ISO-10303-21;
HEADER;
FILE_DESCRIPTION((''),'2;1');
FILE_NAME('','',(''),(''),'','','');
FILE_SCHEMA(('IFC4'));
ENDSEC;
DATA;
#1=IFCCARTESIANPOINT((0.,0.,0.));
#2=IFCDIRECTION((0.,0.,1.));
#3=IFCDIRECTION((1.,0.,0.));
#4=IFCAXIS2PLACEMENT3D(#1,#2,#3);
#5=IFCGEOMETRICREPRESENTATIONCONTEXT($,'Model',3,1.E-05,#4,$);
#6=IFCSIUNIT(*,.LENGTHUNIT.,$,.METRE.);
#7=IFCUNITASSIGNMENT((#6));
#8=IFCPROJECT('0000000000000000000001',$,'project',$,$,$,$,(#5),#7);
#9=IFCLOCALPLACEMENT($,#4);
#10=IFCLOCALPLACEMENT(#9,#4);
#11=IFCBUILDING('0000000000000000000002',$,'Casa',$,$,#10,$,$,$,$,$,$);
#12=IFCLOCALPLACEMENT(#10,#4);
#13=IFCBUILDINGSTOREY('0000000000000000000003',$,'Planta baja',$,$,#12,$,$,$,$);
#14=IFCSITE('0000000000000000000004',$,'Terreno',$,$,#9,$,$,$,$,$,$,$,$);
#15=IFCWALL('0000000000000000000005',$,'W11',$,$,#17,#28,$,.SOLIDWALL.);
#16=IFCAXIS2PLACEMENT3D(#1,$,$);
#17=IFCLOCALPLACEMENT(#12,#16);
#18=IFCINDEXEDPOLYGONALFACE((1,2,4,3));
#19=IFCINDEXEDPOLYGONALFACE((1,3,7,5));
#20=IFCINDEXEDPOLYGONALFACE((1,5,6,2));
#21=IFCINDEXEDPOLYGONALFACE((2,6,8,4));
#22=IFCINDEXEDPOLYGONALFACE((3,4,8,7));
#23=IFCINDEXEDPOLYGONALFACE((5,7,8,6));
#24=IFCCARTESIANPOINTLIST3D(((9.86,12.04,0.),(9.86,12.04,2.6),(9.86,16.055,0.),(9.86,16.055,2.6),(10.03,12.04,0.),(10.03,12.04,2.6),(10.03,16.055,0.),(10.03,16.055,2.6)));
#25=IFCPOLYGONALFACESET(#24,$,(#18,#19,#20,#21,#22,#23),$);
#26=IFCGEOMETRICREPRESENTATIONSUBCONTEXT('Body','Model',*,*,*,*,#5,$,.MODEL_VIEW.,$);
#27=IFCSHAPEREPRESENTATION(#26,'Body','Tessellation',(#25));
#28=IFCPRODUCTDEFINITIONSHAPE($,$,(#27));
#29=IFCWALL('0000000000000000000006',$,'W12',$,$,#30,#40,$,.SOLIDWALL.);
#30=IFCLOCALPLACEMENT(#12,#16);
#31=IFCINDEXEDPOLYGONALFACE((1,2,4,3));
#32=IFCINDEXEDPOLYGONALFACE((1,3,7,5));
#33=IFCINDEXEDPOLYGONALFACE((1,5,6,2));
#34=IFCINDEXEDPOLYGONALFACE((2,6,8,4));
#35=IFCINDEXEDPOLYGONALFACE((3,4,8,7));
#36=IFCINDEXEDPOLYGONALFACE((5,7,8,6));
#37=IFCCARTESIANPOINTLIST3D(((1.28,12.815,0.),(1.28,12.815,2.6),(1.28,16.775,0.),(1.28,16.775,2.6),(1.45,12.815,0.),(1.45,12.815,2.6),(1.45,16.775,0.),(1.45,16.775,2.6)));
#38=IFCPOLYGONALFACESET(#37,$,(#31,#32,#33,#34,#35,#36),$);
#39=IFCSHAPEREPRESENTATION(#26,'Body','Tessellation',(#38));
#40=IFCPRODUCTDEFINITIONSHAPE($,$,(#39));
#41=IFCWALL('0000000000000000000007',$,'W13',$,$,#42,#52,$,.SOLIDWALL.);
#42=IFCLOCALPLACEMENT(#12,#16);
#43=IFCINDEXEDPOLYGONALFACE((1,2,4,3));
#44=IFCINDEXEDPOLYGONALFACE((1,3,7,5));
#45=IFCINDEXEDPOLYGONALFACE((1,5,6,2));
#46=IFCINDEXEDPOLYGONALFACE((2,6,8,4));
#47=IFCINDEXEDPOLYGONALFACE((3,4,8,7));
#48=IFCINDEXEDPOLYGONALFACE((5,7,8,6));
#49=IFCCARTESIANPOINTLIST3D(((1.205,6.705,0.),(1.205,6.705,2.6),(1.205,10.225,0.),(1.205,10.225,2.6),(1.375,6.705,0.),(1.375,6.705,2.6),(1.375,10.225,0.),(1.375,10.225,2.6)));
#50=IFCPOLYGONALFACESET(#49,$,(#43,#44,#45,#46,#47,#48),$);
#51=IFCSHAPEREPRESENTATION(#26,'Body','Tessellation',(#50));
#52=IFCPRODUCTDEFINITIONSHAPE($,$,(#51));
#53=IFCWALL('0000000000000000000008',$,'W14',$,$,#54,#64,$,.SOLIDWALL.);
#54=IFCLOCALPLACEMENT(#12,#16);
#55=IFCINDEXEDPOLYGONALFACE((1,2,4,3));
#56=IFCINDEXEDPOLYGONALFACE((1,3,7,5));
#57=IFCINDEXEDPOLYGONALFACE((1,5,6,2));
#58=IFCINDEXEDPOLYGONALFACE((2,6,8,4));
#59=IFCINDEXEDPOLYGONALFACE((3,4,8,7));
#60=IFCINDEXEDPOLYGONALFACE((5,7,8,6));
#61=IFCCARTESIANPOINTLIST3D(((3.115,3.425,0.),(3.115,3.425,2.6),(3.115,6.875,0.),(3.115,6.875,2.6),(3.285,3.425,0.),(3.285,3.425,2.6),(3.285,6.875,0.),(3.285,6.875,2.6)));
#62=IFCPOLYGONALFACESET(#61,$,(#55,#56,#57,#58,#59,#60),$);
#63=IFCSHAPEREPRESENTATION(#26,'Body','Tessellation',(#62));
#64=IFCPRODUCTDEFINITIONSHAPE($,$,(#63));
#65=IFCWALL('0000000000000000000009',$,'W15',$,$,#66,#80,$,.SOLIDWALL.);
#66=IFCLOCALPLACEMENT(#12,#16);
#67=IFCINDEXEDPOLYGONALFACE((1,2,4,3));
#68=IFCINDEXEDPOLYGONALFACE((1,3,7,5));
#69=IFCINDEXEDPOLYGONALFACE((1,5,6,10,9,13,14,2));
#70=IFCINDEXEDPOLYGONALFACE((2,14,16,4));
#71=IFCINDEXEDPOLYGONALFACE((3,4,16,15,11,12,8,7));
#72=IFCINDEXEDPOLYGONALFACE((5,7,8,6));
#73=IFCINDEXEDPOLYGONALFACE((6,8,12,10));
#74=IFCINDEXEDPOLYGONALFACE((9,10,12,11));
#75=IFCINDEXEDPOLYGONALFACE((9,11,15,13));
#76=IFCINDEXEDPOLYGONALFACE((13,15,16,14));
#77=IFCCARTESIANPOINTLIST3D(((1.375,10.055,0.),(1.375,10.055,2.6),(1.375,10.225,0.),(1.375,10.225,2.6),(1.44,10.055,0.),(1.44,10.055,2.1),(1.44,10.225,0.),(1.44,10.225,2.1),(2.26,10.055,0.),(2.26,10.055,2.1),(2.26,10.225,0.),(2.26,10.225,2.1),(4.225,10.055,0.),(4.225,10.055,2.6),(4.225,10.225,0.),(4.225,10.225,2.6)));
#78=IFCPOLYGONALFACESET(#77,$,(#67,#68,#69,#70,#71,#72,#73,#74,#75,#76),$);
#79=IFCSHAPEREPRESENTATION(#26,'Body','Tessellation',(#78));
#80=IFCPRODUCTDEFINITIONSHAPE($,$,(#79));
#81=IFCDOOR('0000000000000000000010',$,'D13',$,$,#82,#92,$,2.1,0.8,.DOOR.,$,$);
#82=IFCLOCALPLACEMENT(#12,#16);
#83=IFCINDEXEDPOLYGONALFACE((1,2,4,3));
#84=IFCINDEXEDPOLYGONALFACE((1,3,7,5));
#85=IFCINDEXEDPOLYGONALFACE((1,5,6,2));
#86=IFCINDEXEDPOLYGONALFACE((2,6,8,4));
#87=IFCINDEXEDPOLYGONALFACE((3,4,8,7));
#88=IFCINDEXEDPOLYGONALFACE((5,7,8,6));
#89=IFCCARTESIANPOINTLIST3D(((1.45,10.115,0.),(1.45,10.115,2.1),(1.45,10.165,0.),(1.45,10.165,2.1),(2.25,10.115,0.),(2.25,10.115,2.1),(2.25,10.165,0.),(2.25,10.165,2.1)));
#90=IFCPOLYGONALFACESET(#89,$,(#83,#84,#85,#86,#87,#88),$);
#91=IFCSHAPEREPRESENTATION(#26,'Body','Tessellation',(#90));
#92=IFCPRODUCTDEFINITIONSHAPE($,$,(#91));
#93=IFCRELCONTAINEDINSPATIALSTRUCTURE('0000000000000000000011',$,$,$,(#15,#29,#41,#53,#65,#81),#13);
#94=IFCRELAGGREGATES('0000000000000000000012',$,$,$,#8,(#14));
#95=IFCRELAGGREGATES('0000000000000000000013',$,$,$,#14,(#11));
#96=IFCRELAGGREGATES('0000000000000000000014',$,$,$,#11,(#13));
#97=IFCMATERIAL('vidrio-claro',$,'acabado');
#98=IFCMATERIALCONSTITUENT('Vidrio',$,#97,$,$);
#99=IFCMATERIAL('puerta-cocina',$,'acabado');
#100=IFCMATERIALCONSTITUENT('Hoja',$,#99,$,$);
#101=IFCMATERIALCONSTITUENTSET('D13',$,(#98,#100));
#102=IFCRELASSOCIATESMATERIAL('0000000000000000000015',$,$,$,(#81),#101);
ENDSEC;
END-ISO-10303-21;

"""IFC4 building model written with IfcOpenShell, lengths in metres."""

from ifc_helpers import new_model, si_unit, origin_with_axes, place, context, subcontext, project, spatial, line, indexed_curve, outline, extrude, material, constituent, constituent_set, element, fill, save


model = new_model("IFC4")

# Units and contexts
model_context = context("Model", 3, precision=1e-05, world=origin_with_axes())
body_context = subcontext(model_context, "Body", "Model", "MODEL_VIEW")
ifc_project = project(units=[si_unit("LENGTHUNIT", "METRE")], contexts=[model_context])

# Site, building, storey
site_placement = place(None, origin_with_axes())
site = spatial("IfcSite", under=ifc_project, at=site_placement, Name="Terreno")
building_placement = place(site_placement, origin_with_axes())
building = spatial("IfcBuilding", under=site, at=building_placement, Name="Casa")
storey_placement = place(building_placement, origin_with_axes())
storey = spatial("IfcBuildingStorey", under=building, at=storey_placement, Name="Planta baja")

# Shared definitions
ifc_material_1 = material(Name="vidrio-claro", Category="acabado")

# Walls
wall_1_placement = place(storey_placement, origin_with_axes())
element("IfcWall", 1, at=wall_1_placement, inside=storey, Name="W11", PredefinedType="SOLIDWALL", context=body_context, shape_type="SweptSolid", body=[
    extrude(outline(indexed_curve([(9.86, 12.04), (9.86, 16.055), (10.03, 16.055), (10.03, 12.04)], segments=[line(1, 2, 3, 4, 1)])), origin_with_axes(), (0.0, 0.0, 1.0), 2.6),
])
wall_2_placement = place(storey_placement, origin_with_axes())
element("IfcWall", 2, at=wall_2_placement, inside=storey, Name="W12", PredefinedType="SOLIDWALL", context=body_context, shape_type="SweptSolid", body=[
    extrude(outline(indexed_curve([(1.28, 16.775), (1.45, 16.775), (1.45, 12.815), (1.28, 12.815)], segments=[line(1, 2, 3, 4, 1)])), origin_with_axes(), (0.0, 0.0, 1.0), 2.6),
])
wall_3_placement = place(storey_placement, origin_with_axes())
element("IfcWall", 3, at=wall_3_placement, inside=storey, Name="W13", PredefinedType="SOLIDWALL", context=body_context, shape_type="SweptSolid", body=[
    extrude(outline(indexed_curve([(1.375, 6.705), (1.205, 6.705), (1.205, 10.225), (1.375, 10.225)], segments=[line(1, 2, 3, 4, 1)])), origin_with_axes(), (0.0, 0.0, 1.0), 2.6),
])
wall_4_placement = place(storey_placement, origin_with_axes())
element("IfcWall", 4, at=wall_4_placement, inside=storey, Name="W14", PredefinedType="SOLIDWALL", context=body_context, shape_type="SweptSolid", body=[
    extrude(outline(indexed_curve([(3.285, 3.425), (3.115, 3.425), (3.115, 6.875), (3.285, 6.875)], segments=[line(1, 2, 3, 4, 1)])), origin_with_axes(), (0.0, 0.0, 1.0), 2.6),
])

# Wall, opening, door
wall_5_placement = place(storey_placement, origin_with_axes())
wall_5 = element("IfcWall", 5, at=wall_5_placement, inside=storey, Name="W15", PredefinedType="SOLIDWALL", context=body_context, shape_type="SweptSolid", body=[
    extrude(outline(indexed_curve([(4.225, 10.225), (4.225, 10.055), (1.375, 10.055), (1.375, 10.225)], segments=[line(1, 2, 3, 4, 1)])), origin_with_axes(), (0.0, 0.0, 1.0), 2.6),
])
opening_1_placement = place(wall_5_placement, origin_with_axes())
opening_1 = element("IfcOpeningElement", 6, at=opening_1_placement, cuts=wall_5, PredefinedType="OPENING", context=body_context, shape_type="SweptSolid", body=[
    extrude(outline(indexed_curve([(1.44, 10.045), (2.26, 10.045), (2.26, 10.235), (1.44, 10.235)], segments=[line(1, 2, 3, 4, 1)])), origin_with_axes(), (0.0, 0.0, 1.0), 2.1),
])
ifc_constituent_1 = constituent(ifc_material_1, Name="Vidrio")
ifc_material_2 = material(Name="puerta-cocina", Category="acabado")
ifc_constituent_2 = constituent(ifc_material_2, Name="Hoja")
ifc_constituent_set_1 = constituent_set(constituents=[ifc_constituent_1, ifc_constituent_2], Name="D13")
door_1_placement = place(opening_1_placement, origin_with_axes())
door_1 = element("IfcDoor", 7, at=door_1_placement, inside=storey, material=ifc_constituent_set_1, Name="D13", OverallHeight=2.1, OverallWidth=0.8, PredefinedType="DOOR", context=body_context, shape_type="SweptSolid", body=[
    extrude(outline(indexed_curve([(1.45, 10.115), (2.25, 10.115), (2.25, 10.165), (1.45, 10.165)], segments=[line(1, 2, 3, 4, 1)])), origin_with_axes(), (0.0, 0.0, 1.0), 2.1),
])
fill(opening_1, door_1)

save(model, "model.ifc")
